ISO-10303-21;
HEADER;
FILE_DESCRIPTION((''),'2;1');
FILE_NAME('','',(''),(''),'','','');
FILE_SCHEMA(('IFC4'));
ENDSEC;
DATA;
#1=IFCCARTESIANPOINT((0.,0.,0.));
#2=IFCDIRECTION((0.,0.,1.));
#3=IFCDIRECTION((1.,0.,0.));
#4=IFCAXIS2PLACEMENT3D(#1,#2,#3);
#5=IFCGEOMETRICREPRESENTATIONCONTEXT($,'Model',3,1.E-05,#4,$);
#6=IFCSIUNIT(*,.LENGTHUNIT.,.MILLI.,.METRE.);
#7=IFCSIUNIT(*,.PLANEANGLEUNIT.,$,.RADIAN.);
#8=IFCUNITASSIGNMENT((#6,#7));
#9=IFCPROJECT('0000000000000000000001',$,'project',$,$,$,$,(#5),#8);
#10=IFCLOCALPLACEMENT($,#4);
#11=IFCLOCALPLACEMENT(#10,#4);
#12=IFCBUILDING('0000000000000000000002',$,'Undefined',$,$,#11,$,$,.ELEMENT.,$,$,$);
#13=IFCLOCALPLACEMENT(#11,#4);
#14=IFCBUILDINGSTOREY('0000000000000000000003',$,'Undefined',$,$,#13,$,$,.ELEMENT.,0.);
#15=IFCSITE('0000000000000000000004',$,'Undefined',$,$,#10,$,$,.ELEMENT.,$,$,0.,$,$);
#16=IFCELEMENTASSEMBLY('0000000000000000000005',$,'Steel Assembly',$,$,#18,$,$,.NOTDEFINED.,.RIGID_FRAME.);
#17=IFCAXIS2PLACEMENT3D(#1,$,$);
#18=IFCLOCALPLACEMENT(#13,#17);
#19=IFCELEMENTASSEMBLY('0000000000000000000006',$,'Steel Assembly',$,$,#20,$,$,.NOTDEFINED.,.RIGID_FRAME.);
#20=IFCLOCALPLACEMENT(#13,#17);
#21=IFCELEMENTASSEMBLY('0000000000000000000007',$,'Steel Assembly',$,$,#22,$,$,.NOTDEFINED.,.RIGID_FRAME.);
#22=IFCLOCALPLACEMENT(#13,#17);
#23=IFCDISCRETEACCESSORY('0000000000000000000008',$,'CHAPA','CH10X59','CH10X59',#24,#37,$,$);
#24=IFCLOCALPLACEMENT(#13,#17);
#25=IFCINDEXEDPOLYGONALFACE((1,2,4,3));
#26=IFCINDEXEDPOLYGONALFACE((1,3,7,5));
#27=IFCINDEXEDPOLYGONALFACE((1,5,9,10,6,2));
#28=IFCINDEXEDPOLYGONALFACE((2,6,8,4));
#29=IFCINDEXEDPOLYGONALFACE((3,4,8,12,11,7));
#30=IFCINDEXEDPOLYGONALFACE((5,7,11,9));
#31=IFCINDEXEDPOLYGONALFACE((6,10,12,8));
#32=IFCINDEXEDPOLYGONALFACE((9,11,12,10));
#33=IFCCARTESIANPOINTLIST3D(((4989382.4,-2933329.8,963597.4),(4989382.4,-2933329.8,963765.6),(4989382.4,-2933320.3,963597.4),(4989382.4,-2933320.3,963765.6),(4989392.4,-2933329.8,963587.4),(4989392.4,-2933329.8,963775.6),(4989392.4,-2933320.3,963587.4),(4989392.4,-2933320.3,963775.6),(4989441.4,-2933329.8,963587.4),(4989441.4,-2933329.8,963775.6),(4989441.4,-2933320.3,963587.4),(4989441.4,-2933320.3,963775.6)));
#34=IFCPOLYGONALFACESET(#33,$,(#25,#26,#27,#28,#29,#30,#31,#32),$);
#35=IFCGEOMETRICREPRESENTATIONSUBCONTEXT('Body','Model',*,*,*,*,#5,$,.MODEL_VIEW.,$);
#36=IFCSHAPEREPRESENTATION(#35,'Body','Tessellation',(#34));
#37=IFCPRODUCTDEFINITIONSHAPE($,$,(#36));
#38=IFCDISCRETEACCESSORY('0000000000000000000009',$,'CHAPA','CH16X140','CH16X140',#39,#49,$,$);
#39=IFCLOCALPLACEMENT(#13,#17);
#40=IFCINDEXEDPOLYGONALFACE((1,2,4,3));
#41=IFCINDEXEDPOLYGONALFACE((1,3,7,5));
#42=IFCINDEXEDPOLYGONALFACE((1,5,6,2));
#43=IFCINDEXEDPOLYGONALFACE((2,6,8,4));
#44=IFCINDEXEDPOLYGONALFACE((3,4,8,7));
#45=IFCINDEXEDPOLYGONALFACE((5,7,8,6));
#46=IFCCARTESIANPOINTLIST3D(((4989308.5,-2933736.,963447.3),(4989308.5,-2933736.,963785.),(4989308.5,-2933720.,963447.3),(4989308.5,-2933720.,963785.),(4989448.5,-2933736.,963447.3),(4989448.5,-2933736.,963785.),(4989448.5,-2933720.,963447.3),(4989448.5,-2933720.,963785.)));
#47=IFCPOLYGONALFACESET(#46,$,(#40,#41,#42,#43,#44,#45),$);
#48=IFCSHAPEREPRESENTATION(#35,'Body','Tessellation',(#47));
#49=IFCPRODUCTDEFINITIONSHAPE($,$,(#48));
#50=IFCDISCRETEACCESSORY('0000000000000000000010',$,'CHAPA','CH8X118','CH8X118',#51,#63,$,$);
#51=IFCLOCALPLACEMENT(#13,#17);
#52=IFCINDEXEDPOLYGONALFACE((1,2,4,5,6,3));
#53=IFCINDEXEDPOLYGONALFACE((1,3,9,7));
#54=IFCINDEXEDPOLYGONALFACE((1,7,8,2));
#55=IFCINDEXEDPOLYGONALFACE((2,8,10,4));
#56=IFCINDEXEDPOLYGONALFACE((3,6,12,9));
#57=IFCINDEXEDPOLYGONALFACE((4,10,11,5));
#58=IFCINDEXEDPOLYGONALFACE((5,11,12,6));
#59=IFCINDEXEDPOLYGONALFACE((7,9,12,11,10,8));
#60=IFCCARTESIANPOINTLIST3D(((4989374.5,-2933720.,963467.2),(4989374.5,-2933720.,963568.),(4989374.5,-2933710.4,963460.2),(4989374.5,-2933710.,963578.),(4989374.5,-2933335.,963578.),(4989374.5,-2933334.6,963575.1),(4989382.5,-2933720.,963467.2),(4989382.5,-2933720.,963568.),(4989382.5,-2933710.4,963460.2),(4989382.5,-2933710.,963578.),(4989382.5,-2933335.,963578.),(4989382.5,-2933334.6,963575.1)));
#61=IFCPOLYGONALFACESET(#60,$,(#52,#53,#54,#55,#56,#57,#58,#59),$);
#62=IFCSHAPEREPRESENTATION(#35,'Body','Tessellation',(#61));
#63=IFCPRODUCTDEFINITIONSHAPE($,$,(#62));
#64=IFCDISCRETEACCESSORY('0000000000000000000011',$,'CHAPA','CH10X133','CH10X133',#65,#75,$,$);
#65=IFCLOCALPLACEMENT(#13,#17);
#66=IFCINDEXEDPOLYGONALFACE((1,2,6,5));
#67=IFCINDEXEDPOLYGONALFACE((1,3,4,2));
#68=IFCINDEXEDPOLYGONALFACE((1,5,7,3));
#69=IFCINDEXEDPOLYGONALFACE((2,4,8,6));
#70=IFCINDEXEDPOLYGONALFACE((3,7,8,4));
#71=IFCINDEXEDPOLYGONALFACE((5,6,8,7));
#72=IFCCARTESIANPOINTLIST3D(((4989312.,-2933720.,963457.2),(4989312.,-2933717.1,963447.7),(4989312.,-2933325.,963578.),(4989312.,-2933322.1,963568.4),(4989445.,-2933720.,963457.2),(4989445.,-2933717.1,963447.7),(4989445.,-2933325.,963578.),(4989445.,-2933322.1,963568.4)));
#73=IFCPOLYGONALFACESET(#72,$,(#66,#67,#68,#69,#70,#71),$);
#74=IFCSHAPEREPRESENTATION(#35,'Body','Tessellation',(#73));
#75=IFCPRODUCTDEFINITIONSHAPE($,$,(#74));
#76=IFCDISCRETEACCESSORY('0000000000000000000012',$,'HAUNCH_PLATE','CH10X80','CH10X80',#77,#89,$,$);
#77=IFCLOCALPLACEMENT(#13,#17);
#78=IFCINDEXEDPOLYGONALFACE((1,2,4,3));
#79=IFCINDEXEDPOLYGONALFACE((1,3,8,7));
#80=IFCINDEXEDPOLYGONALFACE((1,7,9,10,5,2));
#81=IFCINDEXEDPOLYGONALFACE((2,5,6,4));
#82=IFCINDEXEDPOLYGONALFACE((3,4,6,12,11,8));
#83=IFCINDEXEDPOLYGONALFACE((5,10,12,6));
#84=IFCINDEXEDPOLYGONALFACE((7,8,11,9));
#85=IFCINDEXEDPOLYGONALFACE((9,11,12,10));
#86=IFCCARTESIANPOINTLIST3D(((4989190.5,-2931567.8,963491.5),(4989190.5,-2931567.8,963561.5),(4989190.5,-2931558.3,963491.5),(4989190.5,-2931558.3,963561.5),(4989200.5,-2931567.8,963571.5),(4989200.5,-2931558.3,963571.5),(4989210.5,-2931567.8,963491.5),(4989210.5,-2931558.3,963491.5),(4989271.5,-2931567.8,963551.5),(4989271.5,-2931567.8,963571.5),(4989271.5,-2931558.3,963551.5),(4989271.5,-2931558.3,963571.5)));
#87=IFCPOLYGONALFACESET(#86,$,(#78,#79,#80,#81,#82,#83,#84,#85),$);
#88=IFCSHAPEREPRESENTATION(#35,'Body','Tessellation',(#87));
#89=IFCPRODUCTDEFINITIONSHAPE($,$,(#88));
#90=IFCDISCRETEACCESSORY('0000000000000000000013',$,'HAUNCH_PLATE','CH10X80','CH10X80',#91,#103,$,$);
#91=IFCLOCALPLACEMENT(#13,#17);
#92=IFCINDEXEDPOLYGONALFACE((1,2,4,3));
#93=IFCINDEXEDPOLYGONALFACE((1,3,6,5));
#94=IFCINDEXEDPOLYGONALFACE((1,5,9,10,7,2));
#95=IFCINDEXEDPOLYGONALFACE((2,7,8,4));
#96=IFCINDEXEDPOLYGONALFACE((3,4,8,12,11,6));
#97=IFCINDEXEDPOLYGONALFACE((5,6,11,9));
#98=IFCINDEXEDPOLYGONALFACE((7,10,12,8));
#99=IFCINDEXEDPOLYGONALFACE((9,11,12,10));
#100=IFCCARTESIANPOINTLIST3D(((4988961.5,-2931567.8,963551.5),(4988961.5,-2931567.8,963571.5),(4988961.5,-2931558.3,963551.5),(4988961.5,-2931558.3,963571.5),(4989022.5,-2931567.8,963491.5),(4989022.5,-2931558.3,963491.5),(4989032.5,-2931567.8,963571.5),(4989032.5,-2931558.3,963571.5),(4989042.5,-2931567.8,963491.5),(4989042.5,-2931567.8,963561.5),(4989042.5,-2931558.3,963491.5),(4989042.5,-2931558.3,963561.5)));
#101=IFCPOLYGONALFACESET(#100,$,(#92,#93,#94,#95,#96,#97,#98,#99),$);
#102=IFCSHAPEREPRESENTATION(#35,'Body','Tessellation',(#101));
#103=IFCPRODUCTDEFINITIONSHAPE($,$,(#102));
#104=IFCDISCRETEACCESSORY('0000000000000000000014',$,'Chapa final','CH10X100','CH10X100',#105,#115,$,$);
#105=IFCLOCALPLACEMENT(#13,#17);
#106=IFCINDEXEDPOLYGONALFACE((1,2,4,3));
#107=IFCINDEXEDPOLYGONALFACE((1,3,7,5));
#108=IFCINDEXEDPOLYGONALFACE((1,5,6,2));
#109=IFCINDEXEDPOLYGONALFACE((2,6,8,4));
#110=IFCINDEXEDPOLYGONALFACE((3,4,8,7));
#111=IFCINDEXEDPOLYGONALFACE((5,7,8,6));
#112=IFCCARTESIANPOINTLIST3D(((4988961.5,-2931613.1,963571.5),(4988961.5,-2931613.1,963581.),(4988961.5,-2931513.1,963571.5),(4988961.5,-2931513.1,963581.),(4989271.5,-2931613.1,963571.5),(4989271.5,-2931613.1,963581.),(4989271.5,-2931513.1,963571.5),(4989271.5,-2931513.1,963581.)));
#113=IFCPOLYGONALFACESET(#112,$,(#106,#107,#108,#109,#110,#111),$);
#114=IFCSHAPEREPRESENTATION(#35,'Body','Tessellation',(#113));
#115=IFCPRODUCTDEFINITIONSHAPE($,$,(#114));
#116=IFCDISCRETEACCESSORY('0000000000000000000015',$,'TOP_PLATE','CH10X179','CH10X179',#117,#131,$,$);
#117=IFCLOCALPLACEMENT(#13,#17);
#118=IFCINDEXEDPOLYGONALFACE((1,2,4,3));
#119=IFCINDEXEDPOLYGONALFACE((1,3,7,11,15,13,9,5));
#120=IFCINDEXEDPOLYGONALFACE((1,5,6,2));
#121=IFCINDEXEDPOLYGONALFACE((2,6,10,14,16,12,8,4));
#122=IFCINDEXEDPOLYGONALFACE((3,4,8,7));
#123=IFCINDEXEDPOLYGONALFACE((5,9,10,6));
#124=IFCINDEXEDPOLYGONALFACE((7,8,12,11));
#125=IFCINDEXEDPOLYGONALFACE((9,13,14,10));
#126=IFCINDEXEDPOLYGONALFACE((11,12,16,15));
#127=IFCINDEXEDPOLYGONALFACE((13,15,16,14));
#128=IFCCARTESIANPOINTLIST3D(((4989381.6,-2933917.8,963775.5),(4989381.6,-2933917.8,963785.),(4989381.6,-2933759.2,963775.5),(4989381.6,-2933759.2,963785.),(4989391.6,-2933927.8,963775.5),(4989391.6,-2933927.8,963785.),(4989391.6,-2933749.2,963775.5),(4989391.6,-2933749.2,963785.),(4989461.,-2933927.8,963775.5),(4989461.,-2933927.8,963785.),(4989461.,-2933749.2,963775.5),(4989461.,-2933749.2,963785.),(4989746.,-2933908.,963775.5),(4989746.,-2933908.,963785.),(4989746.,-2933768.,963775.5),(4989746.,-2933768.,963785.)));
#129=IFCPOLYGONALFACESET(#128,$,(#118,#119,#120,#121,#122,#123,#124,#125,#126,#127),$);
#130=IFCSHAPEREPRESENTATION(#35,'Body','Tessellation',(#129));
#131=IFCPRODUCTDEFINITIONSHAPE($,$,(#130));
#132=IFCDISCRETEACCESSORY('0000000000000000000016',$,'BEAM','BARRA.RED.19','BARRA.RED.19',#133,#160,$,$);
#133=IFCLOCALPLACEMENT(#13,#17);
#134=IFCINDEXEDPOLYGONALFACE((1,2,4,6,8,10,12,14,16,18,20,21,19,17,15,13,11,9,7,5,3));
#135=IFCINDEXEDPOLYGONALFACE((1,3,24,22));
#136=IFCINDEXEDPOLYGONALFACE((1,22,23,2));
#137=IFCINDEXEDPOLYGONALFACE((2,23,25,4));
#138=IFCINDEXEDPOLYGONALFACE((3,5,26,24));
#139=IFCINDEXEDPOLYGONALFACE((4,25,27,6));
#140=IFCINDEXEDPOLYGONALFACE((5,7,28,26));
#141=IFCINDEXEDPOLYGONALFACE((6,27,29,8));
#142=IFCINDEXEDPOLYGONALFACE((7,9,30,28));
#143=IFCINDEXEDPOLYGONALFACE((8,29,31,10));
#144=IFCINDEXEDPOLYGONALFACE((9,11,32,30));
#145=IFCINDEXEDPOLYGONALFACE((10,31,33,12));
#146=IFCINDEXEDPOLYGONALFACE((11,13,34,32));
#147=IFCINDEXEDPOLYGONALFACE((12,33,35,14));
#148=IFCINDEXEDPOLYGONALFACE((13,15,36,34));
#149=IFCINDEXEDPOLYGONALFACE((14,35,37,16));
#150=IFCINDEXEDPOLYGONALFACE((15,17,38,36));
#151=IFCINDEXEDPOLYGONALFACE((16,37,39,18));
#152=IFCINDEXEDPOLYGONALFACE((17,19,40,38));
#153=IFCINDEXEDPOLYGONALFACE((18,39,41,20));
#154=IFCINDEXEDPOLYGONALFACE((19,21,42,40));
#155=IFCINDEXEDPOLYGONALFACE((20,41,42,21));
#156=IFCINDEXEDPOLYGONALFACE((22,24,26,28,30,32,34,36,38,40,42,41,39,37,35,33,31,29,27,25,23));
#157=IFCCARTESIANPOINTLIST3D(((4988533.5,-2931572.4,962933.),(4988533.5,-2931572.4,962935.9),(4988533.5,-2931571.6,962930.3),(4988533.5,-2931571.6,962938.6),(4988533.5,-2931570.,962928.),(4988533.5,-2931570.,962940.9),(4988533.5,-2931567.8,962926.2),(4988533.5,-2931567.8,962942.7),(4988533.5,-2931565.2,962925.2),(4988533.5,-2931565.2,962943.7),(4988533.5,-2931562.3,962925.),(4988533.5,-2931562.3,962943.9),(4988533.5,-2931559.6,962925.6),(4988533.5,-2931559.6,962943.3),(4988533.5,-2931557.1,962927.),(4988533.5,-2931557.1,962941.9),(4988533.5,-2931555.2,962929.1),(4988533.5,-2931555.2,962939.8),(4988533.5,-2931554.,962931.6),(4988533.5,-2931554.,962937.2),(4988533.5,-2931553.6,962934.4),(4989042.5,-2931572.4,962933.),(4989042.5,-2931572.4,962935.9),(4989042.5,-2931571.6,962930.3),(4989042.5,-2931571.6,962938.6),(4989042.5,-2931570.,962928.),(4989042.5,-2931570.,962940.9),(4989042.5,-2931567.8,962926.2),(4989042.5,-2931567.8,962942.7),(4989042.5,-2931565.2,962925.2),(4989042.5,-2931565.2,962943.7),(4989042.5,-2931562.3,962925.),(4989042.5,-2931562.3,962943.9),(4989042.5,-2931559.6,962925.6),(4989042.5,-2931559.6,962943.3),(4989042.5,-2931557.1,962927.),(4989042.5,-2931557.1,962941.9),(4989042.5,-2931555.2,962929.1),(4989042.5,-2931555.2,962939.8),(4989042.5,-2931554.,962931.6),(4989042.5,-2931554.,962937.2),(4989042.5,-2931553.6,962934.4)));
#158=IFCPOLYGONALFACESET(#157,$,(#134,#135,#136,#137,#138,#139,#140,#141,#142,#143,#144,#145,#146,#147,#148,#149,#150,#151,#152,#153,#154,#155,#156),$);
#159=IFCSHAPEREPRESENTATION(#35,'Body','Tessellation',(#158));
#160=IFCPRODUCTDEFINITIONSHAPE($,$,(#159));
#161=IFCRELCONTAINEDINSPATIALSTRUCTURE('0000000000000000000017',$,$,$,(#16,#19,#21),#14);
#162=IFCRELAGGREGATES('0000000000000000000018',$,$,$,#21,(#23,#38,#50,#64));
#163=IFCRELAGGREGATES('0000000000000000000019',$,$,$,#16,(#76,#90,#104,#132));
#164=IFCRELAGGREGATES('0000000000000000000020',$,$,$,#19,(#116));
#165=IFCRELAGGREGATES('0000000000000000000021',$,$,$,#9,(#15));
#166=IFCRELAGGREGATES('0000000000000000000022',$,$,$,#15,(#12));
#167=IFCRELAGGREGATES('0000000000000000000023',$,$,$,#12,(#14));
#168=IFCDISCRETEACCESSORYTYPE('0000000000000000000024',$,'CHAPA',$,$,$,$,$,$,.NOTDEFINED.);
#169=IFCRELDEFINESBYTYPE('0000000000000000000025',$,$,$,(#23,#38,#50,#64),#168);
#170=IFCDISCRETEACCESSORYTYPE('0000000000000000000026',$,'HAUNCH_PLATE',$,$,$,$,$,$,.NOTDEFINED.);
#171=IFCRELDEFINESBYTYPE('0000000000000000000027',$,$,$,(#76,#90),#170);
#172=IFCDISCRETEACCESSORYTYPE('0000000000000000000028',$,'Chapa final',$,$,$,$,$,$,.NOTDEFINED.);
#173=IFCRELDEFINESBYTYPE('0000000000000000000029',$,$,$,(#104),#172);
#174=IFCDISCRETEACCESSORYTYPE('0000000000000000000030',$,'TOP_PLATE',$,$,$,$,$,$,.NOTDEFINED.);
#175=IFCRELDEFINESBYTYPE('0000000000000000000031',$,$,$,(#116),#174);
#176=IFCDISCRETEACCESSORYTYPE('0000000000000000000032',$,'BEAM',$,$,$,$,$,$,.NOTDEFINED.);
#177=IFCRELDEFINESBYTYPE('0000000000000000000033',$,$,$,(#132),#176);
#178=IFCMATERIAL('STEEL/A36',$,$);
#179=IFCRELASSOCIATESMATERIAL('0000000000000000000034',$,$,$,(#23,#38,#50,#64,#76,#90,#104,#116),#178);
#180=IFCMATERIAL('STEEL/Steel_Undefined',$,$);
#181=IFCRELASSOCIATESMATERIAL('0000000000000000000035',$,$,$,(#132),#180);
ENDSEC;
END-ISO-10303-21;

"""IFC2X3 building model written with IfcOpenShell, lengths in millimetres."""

from ifc_helpers import new_model, si_unit, frame, origin_with_axes, origin_2d_with_axis, place, context, subcontext, project, spatial, polyline, circle, outline, extrude, material, type_object, element, aggregate, save


model = new_model("IFC2X3")

# Units and contexts
model_context = context("Model", 3, precision=1e-05, world=origin_with_axes())
body_context = subcontext(model_context, "Body", "Model", "MODEL_VIEW")
ifc_project = project(units=[si_unit("LENGTHUNIT", "METRE", prefix="MILLI"), si_unit("PLANEANGLEUNIT", "RADIAN")], contexts=[model_context])

# Site, building, storey
site_placement = place(None, origin_with_axes())
site = spatial("IfcSite", under=ifc_project, at=site_placement, Name="Undefined", CompositionType="ELEMENT", RefElevation=0.0)
building_placement = place(site_placement, origin_with_axes())
building = spatial("IfcBuilding", under=site, at=building_placement, Name="Undefined", CompositionType="ELEMENT")
storey_placement = place(building_placement, origin_with_axes())
storey = spatial("IfcBuildingStorey", under=building, at=storey_placement, Name="Undefined", CompositionType="ELEMENT", Elevation=0.0)

# Element assembly
assembly_1_placement = place(storey_placement, origin_with_axes())
assembly_1 = element("IfcElementAssembly", 1, at=assembly_1_placement, inside=storey, Name="Steel Assembly", AssemblyPlace="NOTDEFINED", PredefinedType="RIGID_FRAME")
ifc_material_1 = material(Name="STEEL/Steel_Undefined")

# Shared definitions
ifc_material_2 = material(Name="STEEL/A36")
discrete_accessory_type_1 = type_object("IfcDiscreteAccessoryType", Name="CHAPA")

# Element assemblies, discrete accessories
assembly_2_placement = place(storey_placement, origin_with_axes())
assembly_2 = element("IfcElementAssembly", 2, at=assembly_2_placement, inside=storey, Name="Steel Assembly", AssemblyPlace="NOTDEFINED", PredefinedType="RIGID_FRAME")
assembly_3_placement = place(storey_placement, origin_with_axes())
assembly_3 = element("IfcElementAssembly", 3, at=assembly_3_placement, inside=storey, Name="Steel Assembly", AssemblyPlace="NOTDEFINED", PredefinedType="RIGID_FRAME")
discrete_accessory_1_placement = place(assembly_3_placement, frame((4989382.4, -2933325.0, 963587.4), z_axis=(0.0, -1.0, 0.0), x_axis=(1.0, 0.0, 0.0)))
discrete_accessory_1 = element("IfcDiscreteAccessory", 4, at=discrete_accessory_1_placement, type_object=discrete_accessory_type_1, material=ifc_material_2, Name="CHAPA", Description="CH10X59", ObjectType="CH10X59", context=body_context, shape_type="SweptSolid", body=[
    extrude(outline(polyline([(0.0, 10.0), (10.0, 0.0), (59.0, 0.0), (59.0, 188.2), (10.0, 188.2), (0.0, 178.2), (0.0, 10.0)])), frame((0.0, 0.0, -4.8), z_axis=(0.0, 0.0, 1.0), x_axis=(1.0, 0.0, 0.0)), (0.0, 0.0, 1.0), 9.5),
])
discrete_accessory_2_placement = place(assembly_3_placement, frame((4989378.5, -2933728.0, 963447.3), z_axis=(0.0, 1.0, 0.0), x_axis=(0.0, 0.0, 1.0)))
discrete_accessory_2 = element("IfcDiscreteAccessory", 5, at=discrete_accessory_2_placement, type_object=discrete_accessory_type_1, material=ifc_material_2, Name="CHAPA", Description="CH16X140", ObjectType="CH16X140", context=body_context, shape_type="SweptSolid", body=[
    extrude(outline(polyline([(0.0, -70.0), (0.0, 70.0), (337.7, 70.0), (337.7, -70.0), (0.0, -70.0)])), frame((0.0, 0.0, -8.0), z_axis=(0.0, 0.0, 1.0), x_axis=(1.0, 0.0, 0.0)), (0.0, 0.0, 1.0), 16.0),
])
discrete_accessory_3_placement = place(assembly_3_placement, frame((4989378.5, -2933720.0, 963457.2), z_axis=(-1.0, 0.0, 0.0), x_axis=(0.0, 0.0, 1.0)))
discrete_accessory_3 = element("IfcDiscreteAccessory", 6, at=discrete_accessory_3_placement, type_object=discrete_accessory_type_1, material=ifc_material_2, Name="CHAPA", Description="CH8X118", ObjectType="CH8X118", context=body_context, shape_type="SweptSolid", body=[
    extrude(outline(polyline([(2.9, 9.6), (10.0, 0.0), (110.8, 0.0), (120.8, 10.0), (120.8, 385.0), (117.8, 385.4), (2.9, 9.6)])), frame((0.0, 0.0, -4.0), z_axis=(0.0, 0.0, 1.0), x_axis=(1.0, 0.0, 0.0)), (0.0, 0.0, 1.0), 8.0),
])
discrete_accessory_4_placement = place(assembly_3_placement, frame((4989378.5, -2933718.5, 963452.5), z_axis=(0.0, 0.292372, -0.956305), x_axis=(0.0, 0.956305, 0.292372)))
discrete_accessory_4 = element("IfcDiscreteAccessory", 7, at=discrete_accessory_4_placement, type_object=discrete_accessory_type_1, material=ifc_material_2, Name="CHAPA", Description="CH10X133", ObjectType="CH10X133", context=body_context, shape_type="SweptSolid", body=[
    extrude(outline(polyline([(0.0, -66.5), (0.0, 66.5), (413.0, 66.5), (413.0, -66.5), (0.0, -66.5)])), frame((0.0, 0.0, -5.0), z_axis=(0.0, 0.0, 1.0), x_axis=(1.0, 0.0, 0.0)), (0.0, 0.0, 1.0), 10.0),
])
aggregate(assembly_3, [discrete_accessory_1, discrete_accessory_2, discrete_accessory_3, discrete_accessory_4])

# Discrete accessories
discrete_accessory_type_2 = type_object("IfcDiscreteAccessoryType", Name="HAUNCH_PLATE")
discrete_accessory_5_placement = place(assembly_1_placement, frame((4989190.5, -2931563.1, 963571.5), z_axis=(0.0, 1.0, 0.0), x_axis=(1.0, 0.0, 0.0)))
discrete_accessory_5 = element("IfcDiscreteAccessory", 8, at=discrete_accessory_5_placement, type_object=discrete_accessory_type_2, material=ifc_material_2, Name="HAUNCH_PLATE", Description="CH10X80", ObjectType="CH10X80", context=body_context, shape_type="SweptSolid", body=[
    extrude(outline(polyline([(0.0, 10.0), (10.0, 0.0), (81.0, 0.0), (81.0, 20.0), (20.0, 80.0), (0.0, 80.0), (0.0, 10.0)])), frame((0.0, 0.0, -4.8), z_axis=(0.0, 0.0, 1.0), x_axis=(1.0, 0.0, 0.0)), (0.0, 0.0, 1.0), 9.5),
])
discrete_accessory_6_placement = place(assembly_1_placement, frame((4988961.5, -2931563.1, 963571.5), z_axis=(0.0, 1.0, 0.0), x_axis=(1.0, 0.0, 0.0)))
discrete_accessory_6 = element("IfcDiscreteAccessory", 9, at=discrete_accessory_6_placement, type_object=discrete_accessory_type_2, material=ifc_material_2, Name="HAUNCH_PLATE", Description="CH10X80", ObjectType="CH10X80", context=body_context, shape_type="SweptSolid", body=[
    extrude(outline(polyline([(0.0, 0.0), (71.0, 0.0), (81.0, 10.0), (81.0, 80.0), (61.0, 80.0), (0.0, 20.0), (0.0, 0.0)])), frame((0.0, 0.0, -4.8), z_axis=(0.0, 0.0, 1.0), x_axis=(1.0, 0.0, 0.0)), (0.0, 0.0, 1.0), 9.5),
])
discrete_accessory_type_3 = type_object("IfcDiscreteAccessoryType", Name="Chapa final")
discrete_accessory_7_placement = place(assembly_1_placement, frame((4989271.5, -2931563.1, 963576.3), z_axis=(0.0, 0.0, -1.0), x_axis=(-1.0, 0.0, 0.0)))
discrete_accessory_7 = element("IfcDiscreteAccessory", 10, at=discrete_accessory_7_placement, type_object=discrete_accessory_type_3, material=ifc_material_2, Name="Chapa final", Description="CH10X100", ObjectType="CH10X100", context=body_context, shape_type="SweptSolid", body=[
    extrude(outline(polyline([(310.0, -50.0), (0.0, -50.0), (0.0, 50.0), (310.0, 50.0), (310.0, -50.0)])), frame((0.0, 0.0, -4.8), z_axis=(0.0, 0.0, 1.0), x_axis=(1.0, 0.0, 0.0)), (0.0, 0.0, 1.0), 9.5),
])
discrete_accessory_type_4 = type_object("IfcDiscreteAccessoryType", Name="TOP_PLATE")
discrete_accessory_8_placement = place(assembly_2_placement, frame((4989461.0, -2933749.2, 963780.3), z_axis=(0.0, 0.0, 1.0), x_axis=(-1.0, 0.0, 0.0)))
discrete_accessory_8 = element("IfcDiscreteAccessory", 11, at=discrete_accessory_8_placement, type_object=discrete_accessory_type_4, material=ifc_material_2, Name="TOP_PLATE", Description="CH10X179", ObjectType="CH10X179", context=body_context, shape_type="SweptSolid", body=[
    extrude(outline(polyline([(0.0, 0.0), (69.4, 0.0), (79.4, 10.0), (79.4, 168.6), (69.4, 178.6), (0.0, 178.6), (-285.0, 158.8), (-285.0, 18.8), (0.0, 0.0)])), frame((0.0, 0.0, -4.8), z_axis=(0.0, 0.0, 1.0), x_axis=(1.0, 0.0, 0.0)), (0.0, 0.0, 1.0), 9.5),
])

# Discrete accessory
discrete_accessory_type_5 = type_object("IfcDiscreteAccessoryType", Name="BEAM")
discrete_accessory_9_placement = place(assembly_1_placement, frame((4988533.5, -2931563.1, 962934.4), z_axis=(0.000003, 0.0, -1.0), x_axis=(1.0, 0.0, 0.000003)))
discrete_accessory_9 = element("IfcDiscreteAccessory", 12, at=discrete_accessory_9_placement, type_object=discrete_accessory_type_5, material=ifc_material_1, Name="BEAM", Description="BARRA.RED.19", ObjectType="BARRA.RED.19", context=body_context, shape_type="SweptSolid", body=[
    extrude(circle(Radius=9.5, at=origin_2d_with_axis()), frame((509.0, 0.0, 0.0), z_axis=(-1.0, 0.0, 0.0), x_axis=(0.0, -1.0, 0.0)), (0.0, 0.0, 1.0), 509.0),
])
aggregate(assembly_1, [discrete_accessory_5, discrete_accessory_6, discrete_accessory_7, discrete_accessory_9])
aggregate(assembly_2, [discrete_accessory_8])

save(model, "model.ifc")
